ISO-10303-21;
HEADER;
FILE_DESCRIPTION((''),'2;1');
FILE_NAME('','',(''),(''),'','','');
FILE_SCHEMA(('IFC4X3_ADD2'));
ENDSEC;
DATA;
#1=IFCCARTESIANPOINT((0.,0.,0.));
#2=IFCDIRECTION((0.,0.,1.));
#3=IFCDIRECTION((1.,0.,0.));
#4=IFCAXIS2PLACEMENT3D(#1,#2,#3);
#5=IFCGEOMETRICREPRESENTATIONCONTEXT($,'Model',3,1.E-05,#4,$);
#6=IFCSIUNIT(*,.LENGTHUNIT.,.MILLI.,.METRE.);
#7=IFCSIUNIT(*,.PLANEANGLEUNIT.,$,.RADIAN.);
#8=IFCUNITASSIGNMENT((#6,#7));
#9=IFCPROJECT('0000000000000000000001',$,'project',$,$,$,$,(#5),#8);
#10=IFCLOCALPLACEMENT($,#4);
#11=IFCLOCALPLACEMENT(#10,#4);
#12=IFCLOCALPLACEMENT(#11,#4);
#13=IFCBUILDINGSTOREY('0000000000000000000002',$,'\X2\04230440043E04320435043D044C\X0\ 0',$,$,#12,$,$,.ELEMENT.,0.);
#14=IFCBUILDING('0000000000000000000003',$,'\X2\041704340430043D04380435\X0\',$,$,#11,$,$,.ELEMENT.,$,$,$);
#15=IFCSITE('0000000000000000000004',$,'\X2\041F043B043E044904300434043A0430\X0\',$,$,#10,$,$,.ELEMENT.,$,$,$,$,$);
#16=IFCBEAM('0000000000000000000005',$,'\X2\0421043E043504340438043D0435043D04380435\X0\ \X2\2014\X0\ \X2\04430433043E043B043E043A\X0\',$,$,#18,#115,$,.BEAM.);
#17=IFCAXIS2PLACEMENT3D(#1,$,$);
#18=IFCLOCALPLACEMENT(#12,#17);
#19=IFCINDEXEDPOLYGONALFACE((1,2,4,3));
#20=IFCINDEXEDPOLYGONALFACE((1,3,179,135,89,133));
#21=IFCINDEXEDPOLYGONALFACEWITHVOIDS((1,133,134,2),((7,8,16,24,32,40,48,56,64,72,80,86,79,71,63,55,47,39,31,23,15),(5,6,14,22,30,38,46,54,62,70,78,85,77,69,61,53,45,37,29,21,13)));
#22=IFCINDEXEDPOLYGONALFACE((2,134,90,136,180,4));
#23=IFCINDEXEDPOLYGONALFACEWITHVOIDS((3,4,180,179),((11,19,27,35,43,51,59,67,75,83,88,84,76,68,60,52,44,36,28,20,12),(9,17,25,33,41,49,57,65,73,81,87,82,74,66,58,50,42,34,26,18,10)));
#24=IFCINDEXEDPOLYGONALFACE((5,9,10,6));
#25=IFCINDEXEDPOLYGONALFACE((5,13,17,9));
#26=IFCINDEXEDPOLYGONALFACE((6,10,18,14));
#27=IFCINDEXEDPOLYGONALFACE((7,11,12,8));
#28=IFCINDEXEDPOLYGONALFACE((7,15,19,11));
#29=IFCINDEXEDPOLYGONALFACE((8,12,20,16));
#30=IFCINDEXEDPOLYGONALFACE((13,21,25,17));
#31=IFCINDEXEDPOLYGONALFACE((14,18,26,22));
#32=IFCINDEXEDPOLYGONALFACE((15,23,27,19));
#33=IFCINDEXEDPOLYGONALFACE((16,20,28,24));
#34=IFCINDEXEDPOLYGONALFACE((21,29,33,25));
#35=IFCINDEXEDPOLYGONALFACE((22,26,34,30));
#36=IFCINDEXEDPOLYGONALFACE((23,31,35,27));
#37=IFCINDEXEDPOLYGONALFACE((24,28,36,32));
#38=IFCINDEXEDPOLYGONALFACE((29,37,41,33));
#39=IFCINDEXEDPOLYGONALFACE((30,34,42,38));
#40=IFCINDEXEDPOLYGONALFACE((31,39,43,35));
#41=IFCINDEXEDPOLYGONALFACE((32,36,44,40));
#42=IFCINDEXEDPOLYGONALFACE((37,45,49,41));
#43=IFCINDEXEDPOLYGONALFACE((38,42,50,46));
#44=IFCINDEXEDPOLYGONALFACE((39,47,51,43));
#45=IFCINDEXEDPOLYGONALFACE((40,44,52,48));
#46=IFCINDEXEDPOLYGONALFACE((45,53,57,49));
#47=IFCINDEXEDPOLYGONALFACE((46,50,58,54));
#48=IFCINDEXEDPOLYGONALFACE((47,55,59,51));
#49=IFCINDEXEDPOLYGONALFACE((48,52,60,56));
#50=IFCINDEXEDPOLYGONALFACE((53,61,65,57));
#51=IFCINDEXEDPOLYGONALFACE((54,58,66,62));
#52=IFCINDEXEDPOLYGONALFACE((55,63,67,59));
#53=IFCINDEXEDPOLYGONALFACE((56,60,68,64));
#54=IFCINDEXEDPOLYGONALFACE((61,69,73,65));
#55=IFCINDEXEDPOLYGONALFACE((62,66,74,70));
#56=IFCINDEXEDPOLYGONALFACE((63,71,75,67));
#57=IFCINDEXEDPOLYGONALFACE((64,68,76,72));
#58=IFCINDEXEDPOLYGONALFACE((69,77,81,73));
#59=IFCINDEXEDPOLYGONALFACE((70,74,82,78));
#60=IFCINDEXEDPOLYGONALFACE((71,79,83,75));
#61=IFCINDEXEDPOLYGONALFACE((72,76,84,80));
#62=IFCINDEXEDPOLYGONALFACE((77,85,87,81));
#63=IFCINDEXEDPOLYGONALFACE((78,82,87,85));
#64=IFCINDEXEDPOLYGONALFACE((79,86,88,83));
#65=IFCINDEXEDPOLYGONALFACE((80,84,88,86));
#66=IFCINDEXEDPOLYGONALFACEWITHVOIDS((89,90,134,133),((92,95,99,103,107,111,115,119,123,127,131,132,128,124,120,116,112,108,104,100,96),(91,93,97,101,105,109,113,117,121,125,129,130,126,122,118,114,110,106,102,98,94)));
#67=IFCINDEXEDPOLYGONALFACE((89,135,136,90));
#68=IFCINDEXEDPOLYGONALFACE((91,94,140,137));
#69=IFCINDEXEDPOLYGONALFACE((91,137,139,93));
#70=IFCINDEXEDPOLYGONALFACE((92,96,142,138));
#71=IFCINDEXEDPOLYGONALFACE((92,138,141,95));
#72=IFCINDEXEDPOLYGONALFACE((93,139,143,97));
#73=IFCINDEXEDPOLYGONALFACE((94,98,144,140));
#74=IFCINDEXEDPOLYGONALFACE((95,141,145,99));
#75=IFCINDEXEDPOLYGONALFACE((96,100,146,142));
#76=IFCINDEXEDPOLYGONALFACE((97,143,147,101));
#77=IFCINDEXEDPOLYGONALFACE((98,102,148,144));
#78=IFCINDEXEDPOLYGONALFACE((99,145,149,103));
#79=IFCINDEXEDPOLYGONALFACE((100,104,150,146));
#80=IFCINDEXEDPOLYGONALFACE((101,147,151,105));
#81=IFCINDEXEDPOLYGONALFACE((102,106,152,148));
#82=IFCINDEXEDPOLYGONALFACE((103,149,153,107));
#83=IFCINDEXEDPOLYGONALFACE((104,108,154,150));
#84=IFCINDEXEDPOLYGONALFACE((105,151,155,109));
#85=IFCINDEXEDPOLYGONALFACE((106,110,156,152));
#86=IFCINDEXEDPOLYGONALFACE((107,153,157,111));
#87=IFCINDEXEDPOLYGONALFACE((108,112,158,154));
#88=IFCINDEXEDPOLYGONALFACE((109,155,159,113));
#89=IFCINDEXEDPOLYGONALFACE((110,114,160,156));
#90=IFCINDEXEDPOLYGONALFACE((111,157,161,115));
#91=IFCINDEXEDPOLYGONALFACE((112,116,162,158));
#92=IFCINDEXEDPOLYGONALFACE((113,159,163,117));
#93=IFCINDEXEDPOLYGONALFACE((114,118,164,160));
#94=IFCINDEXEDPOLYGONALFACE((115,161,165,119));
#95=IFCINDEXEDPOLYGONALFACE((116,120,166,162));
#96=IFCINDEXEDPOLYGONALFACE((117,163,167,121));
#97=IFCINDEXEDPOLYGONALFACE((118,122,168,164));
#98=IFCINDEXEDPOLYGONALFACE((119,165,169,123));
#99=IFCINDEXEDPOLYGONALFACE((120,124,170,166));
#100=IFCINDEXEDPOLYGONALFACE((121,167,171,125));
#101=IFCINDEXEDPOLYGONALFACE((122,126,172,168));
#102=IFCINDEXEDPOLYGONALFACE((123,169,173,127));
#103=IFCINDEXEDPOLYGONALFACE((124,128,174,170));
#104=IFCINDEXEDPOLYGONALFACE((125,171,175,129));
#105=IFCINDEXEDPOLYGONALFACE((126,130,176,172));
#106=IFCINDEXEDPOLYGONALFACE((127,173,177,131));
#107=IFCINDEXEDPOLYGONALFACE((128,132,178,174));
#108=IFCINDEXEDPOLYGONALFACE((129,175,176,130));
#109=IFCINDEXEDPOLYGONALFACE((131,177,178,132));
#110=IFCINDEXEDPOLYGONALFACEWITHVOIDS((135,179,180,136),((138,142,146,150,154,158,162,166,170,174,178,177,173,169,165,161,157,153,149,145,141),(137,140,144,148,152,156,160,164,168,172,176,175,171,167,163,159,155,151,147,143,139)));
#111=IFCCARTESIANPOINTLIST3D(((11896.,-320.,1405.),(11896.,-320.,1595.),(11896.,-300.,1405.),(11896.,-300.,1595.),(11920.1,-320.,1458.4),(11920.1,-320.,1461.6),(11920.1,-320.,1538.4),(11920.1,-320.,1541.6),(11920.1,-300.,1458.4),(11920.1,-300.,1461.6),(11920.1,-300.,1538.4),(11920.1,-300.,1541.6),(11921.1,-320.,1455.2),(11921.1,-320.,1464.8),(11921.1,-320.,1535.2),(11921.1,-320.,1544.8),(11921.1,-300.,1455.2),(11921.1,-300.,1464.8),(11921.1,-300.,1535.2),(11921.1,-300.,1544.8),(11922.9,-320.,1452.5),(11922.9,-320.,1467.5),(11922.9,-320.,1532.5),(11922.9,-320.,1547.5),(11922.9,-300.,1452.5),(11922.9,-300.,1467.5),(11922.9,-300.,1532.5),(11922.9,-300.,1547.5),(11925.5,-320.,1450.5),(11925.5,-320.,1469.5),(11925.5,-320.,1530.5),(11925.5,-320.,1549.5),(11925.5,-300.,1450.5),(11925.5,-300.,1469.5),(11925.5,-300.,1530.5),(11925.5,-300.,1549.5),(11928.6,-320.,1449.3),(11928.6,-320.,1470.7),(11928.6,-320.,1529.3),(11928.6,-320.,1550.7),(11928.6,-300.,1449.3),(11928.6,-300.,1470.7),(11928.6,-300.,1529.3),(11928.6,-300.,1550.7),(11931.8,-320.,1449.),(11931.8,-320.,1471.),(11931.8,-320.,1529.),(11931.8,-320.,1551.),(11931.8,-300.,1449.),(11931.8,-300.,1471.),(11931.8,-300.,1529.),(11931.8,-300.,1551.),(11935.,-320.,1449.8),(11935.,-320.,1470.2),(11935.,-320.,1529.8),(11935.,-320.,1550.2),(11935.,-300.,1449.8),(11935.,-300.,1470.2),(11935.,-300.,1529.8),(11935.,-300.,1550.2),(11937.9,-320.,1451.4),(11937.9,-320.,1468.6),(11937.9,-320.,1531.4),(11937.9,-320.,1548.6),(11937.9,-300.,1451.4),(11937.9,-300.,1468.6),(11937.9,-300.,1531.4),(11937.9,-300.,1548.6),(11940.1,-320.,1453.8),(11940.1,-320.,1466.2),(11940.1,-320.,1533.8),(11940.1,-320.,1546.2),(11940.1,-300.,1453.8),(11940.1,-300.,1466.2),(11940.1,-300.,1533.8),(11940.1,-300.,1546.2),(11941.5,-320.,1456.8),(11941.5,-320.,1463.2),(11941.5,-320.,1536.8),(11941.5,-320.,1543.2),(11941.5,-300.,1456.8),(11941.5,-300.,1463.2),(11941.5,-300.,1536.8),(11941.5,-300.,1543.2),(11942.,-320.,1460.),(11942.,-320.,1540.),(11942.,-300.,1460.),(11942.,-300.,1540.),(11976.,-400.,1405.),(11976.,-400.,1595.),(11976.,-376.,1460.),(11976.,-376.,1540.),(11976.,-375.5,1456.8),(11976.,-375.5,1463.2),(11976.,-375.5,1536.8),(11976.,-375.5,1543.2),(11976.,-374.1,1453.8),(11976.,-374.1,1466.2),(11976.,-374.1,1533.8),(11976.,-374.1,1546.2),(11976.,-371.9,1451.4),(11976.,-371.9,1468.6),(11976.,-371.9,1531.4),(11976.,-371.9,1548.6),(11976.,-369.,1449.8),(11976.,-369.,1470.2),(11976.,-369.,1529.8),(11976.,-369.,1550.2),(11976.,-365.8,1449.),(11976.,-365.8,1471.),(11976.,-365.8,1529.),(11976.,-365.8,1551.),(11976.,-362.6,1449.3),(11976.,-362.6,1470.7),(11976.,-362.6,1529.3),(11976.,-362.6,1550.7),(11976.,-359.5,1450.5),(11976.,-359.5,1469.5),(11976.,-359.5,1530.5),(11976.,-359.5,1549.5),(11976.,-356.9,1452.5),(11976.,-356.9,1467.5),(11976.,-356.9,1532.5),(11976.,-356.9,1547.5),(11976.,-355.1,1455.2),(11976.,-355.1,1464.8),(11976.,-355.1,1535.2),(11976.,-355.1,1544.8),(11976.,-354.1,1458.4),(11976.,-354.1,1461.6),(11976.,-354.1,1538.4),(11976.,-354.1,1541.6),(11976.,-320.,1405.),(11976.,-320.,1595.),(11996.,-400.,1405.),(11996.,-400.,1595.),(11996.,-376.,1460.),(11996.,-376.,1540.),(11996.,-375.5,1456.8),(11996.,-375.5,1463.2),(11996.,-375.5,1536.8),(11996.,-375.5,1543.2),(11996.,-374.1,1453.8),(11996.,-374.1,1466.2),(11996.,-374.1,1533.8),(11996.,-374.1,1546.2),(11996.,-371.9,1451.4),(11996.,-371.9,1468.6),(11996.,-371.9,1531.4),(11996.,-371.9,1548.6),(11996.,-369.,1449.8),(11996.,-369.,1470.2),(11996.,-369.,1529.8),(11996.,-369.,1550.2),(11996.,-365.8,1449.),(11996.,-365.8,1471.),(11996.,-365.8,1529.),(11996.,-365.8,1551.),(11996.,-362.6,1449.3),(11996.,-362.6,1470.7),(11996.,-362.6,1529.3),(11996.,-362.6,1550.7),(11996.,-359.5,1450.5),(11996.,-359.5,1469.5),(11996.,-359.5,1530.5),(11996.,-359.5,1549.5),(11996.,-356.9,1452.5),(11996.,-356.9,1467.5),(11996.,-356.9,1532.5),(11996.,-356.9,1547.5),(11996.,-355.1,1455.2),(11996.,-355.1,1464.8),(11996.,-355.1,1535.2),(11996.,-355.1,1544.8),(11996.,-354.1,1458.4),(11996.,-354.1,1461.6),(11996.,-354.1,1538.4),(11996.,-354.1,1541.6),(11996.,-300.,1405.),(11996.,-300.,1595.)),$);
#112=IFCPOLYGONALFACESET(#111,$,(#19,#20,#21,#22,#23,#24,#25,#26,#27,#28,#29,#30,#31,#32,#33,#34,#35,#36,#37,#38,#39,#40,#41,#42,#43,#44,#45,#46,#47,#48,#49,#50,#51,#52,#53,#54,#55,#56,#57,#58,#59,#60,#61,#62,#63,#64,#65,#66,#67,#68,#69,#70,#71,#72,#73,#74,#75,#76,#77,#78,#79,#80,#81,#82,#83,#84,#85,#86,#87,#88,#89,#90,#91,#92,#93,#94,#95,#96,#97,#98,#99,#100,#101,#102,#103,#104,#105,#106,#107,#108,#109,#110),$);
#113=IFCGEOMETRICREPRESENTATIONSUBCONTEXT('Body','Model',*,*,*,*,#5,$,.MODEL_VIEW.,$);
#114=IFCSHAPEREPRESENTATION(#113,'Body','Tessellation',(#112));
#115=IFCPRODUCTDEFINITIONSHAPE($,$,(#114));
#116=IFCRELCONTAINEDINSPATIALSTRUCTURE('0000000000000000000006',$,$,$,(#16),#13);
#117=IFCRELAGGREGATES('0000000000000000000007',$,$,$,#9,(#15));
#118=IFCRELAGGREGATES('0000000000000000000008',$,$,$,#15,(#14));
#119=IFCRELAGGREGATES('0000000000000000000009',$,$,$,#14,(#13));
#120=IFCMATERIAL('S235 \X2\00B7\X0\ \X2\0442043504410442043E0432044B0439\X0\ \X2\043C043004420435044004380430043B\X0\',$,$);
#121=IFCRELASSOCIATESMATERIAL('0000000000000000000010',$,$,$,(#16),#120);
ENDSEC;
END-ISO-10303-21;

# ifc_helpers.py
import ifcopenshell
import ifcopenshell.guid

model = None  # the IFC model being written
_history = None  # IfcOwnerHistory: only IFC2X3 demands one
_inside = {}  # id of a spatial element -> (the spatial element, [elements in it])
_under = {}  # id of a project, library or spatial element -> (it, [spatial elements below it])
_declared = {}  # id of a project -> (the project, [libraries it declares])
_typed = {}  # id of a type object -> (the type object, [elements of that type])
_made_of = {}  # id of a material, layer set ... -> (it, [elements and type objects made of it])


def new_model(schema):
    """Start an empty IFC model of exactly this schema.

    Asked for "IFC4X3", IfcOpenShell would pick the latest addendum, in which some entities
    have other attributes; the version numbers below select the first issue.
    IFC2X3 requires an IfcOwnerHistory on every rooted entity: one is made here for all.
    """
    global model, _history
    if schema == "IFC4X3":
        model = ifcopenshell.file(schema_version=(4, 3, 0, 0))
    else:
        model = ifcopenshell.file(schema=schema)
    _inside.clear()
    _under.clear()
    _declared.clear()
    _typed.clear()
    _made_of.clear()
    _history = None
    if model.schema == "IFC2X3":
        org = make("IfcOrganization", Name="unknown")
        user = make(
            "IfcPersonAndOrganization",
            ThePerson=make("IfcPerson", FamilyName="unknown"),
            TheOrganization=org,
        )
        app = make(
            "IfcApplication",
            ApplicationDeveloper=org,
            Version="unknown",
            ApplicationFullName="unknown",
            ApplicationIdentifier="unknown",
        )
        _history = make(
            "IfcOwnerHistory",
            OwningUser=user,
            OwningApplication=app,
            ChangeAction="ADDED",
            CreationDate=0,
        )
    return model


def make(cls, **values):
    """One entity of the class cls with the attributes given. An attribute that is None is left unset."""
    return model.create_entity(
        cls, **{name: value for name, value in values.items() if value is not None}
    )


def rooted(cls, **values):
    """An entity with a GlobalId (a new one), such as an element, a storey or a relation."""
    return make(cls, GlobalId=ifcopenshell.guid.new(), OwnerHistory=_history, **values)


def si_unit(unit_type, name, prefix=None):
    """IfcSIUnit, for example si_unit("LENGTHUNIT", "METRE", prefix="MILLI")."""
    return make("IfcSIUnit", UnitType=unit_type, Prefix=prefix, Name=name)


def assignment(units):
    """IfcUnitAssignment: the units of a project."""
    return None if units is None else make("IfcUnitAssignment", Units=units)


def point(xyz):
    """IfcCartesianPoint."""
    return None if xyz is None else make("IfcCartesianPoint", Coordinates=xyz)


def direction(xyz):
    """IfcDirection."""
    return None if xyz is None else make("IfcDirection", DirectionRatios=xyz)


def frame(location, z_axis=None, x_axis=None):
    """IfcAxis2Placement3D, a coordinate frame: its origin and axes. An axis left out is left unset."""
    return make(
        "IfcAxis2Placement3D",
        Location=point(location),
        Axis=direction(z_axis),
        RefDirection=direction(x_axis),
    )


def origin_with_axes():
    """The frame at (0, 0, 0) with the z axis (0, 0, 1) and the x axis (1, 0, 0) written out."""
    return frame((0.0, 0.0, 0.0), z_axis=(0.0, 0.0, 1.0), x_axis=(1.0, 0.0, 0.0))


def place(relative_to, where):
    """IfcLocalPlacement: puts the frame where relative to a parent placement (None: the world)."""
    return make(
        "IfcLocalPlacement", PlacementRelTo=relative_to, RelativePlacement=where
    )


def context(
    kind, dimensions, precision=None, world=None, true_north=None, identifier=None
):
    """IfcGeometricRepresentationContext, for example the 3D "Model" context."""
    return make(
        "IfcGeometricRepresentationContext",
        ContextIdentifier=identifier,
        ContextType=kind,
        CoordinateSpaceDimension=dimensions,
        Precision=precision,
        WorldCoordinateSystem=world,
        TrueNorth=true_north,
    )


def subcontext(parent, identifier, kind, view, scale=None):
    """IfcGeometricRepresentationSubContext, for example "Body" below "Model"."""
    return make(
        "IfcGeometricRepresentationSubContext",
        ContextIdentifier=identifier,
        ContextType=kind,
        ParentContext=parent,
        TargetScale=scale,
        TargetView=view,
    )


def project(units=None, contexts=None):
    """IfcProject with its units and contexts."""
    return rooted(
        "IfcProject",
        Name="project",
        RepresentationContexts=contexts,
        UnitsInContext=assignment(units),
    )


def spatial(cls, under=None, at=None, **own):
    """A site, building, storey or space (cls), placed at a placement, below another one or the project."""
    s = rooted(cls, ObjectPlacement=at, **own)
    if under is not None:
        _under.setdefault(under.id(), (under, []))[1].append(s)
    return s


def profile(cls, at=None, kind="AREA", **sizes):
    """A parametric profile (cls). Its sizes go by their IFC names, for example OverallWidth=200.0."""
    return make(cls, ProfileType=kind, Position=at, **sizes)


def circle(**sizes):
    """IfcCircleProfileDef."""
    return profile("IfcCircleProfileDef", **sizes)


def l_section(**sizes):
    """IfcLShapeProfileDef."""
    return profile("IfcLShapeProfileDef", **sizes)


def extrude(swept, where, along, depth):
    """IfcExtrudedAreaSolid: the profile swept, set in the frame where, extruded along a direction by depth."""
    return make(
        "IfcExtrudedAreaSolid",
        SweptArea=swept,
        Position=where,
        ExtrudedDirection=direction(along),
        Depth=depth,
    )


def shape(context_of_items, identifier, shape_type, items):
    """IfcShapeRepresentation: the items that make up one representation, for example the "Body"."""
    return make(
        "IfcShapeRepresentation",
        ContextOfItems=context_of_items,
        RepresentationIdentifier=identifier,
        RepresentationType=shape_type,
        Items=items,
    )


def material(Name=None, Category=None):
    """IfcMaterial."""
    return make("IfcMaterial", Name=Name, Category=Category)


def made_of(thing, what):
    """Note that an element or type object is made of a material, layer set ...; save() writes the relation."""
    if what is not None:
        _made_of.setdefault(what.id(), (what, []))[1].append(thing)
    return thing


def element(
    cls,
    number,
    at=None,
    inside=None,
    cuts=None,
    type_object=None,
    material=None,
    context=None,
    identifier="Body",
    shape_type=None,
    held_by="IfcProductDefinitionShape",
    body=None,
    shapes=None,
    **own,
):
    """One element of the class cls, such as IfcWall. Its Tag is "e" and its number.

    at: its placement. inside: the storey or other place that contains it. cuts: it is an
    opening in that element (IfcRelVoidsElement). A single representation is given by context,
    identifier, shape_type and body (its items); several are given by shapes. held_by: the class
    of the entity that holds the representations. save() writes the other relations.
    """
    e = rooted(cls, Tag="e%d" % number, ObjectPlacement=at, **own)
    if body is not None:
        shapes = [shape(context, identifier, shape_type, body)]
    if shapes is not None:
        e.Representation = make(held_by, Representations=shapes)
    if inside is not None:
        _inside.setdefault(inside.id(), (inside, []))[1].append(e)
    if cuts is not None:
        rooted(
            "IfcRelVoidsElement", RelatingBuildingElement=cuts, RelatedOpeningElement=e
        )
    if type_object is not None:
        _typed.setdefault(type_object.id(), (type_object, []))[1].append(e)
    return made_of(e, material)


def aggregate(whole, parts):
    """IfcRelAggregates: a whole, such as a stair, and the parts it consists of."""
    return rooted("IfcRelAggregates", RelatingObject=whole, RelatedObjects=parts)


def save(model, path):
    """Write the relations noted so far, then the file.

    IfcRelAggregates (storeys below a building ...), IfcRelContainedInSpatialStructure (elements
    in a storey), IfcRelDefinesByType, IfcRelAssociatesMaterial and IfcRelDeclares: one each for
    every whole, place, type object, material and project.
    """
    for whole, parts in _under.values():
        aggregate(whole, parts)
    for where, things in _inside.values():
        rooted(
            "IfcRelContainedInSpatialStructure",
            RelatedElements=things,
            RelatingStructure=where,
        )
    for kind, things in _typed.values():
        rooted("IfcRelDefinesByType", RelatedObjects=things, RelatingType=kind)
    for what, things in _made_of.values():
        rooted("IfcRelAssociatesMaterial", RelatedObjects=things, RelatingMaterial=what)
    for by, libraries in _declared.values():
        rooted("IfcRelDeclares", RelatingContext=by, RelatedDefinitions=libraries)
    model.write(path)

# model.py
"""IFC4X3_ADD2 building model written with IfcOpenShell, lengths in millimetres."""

from ifc_helpers import new_model, si_unit, frame, origin_with_axes, place, context, subcontext, project, spatial, circle, l_section, extrude, material, element, save


model = new_model("IFC4X3_ADD2")

# Units and contexts
model_context = context("Model", 3, precision=1e-05, world=origin_with_axes())
body_context = subcontext(model_context, "Body", "Model", "MODEL_VIEW")
ifc_project = project(units=[si_unit("LENGTHUNIT", "METRE", prefix="MILLI"), si_unit("PLANEANGLEUNIT", "RADIAN")], contexts=[model_context])

# Site, building, storey
site_placement = place(None, origin_with_axes())
site = spatial("IfcSite", under=ifc_project, at=site_placement, Name="Площадка", CompositionType="ELEMENT")
building_placement = place(site_placement, origin_with_axes())
building = spatial("IfcBuilding", under=site, at=building_placement, Name="Здание", CompositionType="ELEMENT")
storey_placement = place(building_placement, origin_with_axes())
storey = spatial("IfcBuildingStorey", under=building, at=storey_placement, Name="Уровень 0", CompositionType="ELEMENT", Elevation=0.0)

# Shared definitions
ifc_material = material(Name="S235 · тестовый материал")

# Beam, openings
beam_1_placement = place(storey_placement, frame((11946.0, -350.0, 1595.0), z_axis=(0.0, 0.0, -1.0), x_axis=(0.0, -1.0, 0.0)))
beam_1 = element("IfcBeam", 1, at=beam_1_placement, inside=storey, material=ifc_material, Name="Соединение — уголок", PredefinedType="BEAM", context=body_context, shape_type="SweptSolid", body=[
    extrude(l_section(Depth=100.0, Width=100.0, Thickness=20.0), origin_with_axes(), (0.0, 0.0, 1.0), 190.0),
])
opening_1_placement = place(beam_1_placement, frame((15.0, -29.0, 55.0), z_axis=(0.0, -1.0, 0.0), x_axis=(1.0, 0.0, 0.0)))
element("IfcOpeningElement", 2, at=opening_1_placement, cuts=beam_1, PredefinedType="OPENING", context=body_context, shape_type="SweptSolid", body=[
    extrude(circle(Radius=11.0), origin_with_axes(), (0.0, 0.0, 1.0), 30.0),
])
opening_2_placement = place(beam_1_placement, frame((15.0, -29.0, 135.0), z_axis=(0.0, -1.0, 0.0), x_axis=(1.0, 0.0, 0.0)))
element("IfcOpeningElement", 3, at=opening_2_placement, cuts=beam_1, PredefinedType="OPENING", context=body_context, shape_type="SweptSolid", body=[
    extrude(circle(Radius=11.0), origin_with_axes(), (0.0, 0.0, 1.0), 30.0),
])
opening_3_placement = place(beam_1_placement, frame((-29.0, 15.0, 55.0), z_axis=(-1.0, 0.0, 0.0), x_axis=(0.0, -1.0, 0.0)))
element("IfcOpeningElement", 4, at=opening_3_placement, cuts=beam_1, PredefinedType="OPENING", context=body_context, shape_type="SweptSolid", body=[
    extrude(circle(Radius=11.0), origin_with_axes(), (0.0, 0.0, 1.0), 42.0),
])
opening_4_placement = place(beam_1_placement, frame((-29.0, 15.0, 135.0), z_axis=(-1.0, 0.0, 0.0), x_axis=(0.0, -1.0, 0.0)))
element("IfcOpeningElement", 5, at=opening_4_placement, cuts=beam_1, PredefinedType="OPENING", context=body_context, shape_type="SweptSolid", body=[
    extrude(circle(Radius=11.0), origin_with_axes(), (0.0, 0.0, 1.0), 42.0),
])

save(model, "model.ifc")
